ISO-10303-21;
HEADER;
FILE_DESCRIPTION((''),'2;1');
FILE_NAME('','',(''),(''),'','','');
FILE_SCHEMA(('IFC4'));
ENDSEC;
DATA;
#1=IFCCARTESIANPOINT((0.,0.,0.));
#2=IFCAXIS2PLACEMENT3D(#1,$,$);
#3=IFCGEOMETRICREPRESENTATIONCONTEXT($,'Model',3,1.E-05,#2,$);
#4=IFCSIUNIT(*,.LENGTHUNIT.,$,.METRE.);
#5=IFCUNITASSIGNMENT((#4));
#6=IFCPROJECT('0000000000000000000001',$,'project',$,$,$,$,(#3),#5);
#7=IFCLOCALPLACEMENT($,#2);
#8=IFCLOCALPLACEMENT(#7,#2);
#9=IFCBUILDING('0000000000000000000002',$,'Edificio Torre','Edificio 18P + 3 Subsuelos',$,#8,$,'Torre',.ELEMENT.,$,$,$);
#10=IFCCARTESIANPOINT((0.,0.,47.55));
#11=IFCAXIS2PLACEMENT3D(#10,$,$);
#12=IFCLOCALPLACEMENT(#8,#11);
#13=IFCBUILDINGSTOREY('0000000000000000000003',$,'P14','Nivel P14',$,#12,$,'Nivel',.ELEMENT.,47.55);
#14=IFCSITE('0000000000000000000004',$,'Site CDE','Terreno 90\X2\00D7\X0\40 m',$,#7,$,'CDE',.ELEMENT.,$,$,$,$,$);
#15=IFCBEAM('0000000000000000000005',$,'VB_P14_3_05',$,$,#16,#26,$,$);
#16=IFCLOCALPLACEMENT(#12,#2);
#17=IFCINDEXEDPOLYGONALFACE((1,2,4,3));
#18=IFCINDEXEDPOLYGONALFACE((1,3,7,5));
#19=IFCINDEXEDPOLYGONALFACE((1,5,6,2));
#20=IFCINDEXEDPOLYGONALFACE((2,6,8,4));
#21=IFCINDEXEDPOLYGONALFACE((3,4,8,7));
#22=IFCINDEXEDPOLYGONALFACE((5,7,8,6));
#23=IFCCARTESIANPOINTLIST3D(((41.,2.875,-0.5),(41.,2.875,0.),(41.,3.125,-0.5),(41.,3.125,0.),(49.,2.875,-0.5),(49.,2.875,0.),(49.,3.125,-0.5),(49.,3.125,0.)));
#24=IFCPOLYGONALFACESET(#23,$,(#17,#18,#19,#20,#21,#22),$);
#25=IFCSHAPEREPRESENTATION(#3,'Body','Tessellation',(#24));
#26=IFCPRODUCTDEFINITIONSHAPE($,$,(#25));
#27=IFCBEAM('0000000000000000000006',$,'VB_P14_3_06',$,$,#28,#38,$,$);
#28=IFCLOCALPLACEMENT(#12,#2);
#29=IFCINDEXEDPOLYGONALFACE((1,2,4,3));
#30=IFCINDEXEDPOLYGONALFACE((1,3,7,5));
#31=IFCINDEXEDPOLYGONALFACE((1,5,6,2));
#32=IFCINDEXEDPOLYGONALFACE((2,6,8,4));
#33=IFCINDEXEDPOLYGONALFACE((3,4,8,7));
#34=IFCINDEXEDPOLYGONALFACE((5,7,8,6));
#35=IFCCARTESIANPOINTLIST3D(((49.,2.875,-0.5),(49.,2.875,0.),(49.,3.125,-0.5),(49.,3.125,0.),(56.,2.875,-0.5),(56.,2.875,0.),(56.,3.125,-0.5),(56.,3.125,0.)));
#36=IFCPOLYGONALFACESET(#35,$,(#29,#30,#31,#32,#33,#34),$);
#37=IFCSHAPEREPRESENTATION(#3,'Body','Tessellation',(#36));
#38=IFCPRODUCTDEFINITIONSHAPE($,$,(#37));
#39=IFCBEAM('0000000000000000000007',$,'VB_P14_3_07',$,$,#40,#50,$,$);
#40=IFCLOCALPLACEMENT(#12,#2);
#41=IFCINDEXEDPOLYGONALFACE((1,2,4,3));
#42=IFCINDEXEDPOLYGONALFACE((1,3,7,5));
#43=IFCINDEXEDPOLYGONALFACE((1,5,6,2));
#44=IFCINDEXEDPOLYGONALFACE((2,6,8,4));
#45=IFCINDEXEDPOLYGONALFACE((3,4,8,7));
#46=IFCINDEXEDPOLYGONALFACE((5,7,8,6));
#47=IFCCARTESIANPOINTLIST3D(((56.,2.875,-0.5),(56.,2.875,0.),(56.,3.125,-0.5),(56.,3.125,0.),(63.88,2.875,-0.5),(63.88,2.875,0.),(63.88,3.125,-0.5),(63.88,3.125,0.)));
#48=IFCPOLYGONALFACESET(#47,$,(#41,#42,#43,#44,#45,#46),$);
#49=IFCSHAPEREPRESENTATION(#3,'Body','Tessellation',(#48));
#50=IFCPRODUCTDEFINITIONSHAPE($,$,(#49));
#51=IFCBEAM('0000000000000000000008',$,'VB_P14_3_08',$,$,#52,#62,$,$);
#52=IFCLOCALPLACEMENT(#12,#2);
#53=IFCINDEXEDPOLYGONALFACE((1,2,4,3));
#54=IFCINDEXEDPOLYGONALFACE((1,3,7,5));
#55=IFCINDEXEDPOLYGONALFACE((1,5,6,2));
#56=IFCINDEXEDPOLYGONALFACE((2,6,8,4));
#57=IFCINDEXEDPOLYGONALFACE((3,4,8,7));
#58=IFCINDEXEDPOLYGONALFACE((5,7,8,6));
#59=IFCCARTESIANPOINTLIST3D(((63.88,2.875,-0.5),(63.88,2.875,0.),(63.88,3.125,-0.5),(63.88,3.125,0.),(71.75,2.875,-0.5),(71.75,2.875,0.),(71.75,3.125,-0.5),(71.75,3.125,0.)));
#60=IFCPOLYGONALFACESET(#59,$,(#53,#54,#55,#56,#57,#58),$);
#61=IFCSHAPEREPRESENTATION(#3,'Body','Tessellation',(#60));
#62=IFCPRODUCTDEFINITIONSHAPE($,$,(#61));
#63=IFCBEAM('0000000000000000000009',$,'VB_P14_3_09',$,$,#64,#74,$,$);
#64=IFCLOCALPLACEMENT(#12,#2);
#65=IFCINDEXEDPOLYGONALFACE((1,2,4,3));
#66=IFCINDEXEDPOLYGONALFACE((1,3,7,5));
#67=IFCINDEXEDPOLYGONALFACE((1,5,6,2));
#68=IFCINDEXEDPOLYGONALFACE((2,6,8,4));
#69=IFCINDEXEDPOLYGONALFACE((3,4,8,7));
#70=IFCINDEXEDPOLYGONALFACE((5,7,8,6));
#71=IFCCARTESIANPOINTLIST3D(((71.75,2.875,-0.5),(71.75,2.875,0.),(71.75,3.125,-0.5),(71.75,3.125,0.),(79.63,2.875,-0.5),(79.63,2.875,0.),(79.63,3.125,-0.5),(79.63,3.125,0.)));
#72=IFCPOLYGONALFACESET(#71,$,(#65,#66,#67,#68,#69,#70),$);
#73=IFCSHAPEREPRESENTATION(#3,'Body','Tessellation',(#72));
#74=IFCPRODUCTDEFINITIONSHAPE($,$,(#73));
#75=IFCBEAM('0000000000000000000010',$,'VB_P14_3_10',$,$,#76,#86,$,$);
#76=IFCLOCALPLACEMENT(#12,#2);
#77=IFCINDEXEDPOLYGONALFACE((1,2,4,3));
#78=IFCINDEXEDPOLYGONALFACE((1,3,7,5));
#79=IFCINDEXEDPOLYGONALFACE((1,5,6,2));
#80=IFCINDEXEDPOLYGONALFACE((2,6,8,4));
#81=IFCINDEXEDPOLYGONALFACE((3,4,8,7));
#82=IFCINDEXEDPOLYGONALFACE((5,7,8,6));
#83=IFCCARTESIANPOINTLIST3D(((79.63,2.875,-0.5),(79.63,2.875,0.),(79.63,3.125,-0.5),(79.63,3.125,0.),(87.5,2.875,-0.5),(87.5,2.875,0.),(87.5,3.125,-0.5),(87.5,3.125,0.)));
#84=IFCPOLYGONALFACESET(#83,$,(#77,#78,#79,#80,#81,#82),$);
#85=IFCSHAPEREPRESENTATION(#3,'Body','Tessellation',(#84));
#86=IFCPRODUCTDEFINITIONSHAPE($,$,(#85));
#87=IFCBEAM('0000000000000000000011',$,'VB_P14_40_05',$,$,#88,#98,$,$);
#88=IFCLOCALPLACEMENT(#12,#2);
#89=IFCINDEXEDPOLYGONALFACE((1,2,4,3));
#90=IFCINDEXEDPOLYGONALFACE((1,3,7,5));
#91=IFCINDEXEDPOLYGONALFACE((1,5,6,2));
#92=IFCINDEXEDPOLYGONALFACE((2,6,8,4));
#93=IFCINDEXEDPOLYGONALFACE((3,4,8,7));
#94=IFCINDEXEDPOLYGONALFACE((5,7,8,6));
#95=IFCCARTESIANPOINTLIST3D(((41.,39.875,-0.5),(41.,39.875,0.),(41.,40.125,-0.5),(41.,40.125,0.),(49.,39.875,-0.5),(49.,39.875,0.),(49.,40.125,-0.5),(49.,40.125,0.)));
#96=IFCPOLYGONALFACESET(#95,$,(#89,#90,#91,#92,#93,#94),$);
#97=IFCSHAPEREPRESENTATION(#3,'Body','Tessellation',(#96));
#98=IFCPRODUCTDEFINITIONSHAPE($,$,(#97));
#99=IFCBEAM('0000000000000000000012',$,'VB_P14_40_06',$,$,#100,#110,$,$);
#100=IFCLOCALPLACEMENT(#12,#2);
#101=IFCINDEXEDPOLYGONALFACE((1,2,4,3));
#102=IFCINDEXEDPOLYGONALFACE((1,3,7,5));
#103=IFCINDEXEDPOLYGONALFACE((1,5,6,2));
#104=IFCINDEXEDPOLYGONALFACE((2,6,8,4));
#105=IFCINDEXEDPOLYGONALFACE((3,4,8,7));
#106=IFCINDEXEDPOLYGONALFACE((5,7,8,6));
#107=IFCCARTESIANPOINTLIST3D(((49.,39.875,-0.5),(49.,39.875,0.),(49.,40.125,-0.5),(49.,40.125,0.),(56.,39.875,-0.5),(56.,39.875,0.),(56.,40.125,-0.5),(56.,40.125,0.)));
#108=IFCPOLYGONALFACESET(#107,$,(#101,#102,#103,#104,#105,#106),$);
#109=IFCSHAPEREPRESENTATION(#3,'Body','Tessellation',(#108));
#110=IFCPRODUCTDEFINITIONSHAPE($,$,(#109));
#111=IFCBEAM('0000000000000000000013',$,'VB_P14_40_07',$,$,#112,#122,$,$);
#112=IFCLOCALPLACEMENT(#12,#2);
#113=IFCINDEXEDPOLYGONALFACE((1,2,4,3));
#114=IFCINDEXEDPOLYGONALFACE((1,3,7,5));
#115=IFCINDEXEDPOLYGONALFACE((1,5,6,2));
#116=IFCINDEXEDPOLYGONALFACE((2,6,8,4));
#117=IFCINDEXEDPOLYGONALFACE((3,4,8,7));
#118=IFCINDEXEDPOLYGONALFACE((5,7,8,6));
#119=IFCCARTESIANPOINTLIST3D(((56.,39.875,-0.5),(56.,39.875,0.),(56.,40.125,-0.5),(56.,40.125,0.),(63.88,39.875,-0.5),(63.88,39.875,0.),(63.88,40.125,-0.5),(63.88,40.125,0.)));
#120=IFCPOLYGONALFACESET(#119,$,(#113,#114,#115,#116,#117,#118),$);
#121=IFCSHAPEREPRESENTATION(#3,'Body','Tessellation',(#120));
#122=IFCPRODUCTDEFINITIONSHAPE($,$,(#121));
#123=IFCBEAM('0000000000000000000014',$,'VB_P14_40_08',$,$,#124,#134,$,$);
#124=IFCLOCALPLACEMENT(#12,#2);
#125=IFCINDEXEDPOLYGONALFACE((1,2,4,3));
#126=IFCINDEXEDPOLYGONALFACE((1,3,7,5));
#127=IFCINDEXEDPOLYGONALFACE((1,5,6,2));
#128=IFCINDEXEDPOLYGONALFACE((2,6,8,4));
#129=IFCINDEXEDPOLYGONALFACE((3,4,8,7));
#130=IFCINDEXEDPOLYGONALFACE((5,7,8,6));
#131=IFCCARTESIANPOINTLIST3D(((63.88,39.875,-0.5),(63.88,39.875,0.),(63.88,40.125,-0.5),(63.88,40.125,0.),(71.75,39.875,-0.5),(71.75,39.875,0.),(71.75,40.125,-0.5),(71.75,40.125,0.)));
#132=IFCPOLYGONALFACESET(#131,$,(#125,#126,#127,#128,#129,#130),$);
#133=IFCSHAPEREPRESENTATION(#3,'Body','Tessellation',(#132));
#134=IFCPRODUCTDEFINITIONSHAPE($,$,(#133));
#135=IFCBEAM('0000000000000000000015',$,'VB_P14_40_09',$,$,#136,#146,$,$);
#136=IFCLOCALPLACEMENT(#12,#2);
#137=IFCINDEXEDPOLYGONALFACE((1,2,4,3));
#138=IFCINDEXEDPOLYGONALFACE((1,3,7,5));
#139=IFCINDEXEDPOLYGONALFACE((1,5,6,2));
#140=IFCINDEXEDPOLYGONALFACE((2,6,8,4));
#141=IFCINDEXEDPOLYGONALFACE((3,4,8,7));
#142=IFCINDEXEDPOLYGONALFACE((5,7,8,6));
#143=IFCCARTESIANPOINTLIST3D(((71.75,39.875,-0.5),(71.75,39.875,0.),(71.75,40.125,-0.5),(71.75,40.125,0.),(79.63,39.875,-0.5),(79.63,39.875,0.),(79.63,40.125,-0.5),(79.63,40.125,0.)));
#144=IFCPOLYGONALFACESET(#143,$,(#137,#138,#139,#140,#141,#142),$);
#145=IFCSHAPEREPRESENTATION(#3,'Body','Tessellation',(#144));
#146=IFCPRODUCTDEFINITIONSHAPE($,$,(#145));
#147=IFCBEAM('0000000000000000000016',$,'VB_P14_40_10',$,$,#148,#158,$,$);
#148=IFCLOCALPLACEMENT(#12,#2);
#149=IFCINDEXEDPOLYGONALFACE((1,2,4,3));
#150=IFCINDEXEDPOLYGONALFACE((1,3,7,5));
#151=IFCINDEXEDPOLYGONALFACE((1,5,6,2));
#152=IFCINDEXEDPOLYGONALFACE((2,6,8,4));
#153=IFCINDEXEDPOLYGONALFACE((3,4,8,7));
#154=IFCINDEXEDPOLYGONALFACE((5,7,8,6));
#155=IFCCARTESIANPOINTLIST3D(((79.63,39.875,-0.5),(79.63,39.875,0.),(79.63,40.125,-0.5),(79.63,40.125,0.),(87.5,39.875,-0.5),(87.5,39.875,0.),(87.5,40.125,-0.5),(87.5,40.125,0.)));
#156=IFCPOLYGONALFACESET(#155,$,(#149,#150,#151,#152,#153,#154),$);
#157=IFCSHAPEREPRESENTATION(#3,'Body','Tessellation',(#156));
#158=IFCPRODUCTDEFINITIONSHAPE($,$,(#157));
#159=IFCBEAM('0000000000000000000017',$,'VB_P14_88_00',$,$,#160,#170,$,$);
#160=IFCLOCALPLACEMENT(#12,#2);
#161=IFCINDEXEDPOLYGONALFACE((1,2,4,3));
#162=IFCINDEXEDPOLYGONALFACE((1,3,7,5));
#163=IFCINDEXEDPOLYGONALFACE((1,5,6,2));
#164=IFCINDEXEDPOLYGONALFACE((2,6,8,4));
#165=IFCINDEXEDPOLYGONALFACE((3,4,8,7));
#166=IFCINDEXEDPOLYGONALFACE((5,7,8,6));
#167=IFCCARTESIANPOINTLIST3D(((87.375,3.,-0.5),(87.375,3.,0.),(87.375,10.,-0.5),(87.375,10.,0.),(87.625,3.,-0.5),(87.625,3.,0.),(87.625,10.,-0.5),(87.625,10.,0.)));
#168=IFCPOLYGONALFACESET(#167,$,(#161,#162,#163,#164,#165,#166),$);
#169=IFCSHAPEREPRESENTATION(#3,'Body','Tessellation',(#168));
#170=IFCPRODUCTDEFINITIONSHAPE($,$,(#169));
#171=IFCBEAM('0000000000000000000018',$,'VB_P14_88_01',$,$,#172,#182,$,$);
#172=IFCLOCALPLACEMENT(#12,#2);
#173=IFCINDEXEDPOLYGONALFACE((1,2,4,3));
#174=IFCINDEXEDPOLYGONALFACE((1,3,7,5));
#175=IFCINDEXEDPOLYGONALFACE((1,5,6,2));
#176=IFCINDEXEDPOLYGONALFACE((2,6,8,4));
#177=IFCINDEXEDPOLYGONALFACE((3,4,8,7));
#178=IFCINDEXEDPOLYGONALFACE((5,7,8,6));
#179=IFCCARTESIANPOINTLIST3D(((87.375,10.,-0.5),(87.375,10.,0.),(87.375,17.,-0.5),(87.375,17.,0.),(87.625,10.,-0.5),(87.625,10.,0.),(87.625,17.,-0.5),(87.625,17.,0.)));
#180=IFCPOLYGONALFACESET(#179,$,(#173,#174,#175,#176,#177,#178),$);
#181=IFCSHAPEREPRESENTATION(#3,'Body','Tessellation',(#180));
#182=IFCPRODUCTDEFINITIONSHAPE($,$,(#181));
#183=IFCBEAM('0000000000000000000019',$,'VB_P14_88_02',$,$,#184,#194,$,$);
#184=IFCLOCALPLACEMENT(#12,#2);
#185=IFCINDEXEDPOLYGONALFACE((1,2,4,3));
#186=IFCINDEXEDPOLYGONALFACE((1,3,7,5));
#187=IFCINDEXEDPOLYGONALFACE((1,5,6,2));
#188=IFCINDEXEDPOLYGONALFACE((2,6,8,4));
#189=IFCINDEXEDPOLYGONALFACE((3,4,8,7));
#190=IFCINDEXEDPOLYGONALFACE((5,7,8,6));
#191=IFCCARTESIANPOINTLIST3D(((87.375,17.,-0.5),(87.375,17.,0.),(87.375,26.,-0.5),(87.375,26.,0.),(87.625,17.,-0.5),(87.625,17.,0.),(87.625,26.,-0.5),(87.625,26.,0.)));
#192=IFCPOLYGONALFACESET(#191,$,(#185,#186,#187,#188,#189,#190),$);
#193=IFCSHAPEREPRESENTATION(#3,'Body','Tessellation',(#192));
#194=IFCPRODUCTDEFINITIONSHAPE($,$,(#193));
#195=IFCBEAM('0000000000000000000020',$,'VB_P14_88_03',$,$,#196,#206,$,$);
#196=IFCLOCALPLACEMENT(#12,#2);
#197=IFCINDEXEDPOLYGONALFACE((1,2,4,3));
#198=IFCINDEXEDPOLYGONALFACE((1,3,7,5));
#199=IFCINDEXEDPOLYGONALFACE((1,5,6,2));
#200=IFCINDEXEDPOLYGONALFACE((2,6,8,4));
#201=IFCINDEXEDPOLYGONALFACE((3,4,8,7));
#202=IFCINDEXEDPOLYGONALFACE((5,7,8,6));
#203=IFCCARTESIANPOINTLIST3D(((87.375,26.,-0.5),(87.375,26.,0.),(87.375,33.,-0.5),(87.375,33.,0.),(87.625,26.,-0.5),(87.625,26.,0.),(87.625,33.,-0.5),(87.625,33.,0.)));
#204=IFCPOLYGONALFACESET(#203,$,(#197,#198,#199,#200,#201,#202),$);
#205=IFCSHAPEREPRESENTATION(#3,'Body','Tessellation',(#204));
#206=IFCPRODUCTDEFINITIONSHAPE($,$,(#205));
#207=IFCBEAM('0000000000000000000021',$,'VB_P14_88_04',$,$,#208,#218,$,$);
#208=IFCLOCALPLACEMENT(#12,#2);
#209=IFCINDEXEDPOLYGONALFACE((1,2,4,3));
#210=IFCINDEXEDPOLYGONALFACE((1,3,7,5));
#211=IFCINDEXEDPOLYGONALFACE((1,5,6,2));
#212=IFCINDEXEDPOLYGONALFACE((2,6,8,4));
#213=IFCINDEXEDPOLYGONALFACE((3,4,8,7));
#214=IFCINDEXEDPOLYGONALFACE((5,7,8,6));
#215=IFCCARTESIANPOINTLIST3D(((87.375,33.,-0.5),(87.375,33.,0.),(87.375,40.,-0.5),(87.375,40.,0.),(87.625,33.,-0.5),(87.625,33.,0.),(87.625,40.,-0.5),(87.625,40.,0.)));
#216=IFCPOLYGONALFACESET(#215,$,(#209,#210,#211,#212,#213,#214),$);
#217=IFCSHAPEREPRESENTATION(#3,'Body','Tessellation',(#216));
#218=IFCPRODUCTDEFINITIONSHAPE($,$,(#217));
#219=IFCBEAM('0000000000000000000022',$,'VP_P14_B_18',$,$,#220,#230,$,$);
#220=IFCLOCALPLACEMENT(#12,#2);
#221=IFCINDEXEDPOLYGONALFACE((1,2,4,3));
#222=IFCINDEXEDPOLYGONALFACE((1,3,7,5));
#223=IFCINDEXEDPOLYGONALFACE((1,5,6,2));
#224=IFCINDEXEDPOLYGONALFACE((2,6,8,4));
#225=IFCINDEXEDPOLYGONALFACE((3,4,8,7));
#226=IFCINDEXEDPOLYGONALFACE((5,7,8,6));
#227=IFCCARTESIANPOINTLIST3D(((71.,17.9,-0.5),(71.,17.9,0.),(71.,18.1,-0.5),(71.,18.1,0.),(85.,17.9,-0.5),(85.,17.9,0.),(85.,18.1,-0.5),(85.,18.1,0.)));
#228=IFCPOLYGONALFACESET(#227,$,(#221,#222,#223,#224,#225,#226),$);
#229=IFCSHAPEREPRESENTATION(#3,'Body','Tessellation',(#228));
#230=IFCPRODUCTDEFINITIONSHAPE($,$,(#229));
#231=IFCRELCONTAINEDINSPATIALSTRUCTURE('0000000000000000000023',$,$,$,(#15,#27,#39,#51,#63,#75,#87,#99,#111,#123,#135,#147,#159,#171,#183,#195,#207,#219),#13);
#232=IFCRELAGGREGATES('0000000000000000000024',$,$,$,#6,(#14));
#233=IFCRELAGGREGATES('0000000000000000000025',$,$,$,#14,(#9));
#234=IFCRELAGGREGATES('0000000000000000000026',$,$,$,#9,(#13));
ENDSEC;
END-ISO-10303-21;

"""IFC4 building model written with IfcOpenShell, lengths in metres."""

from ifc_helpers import new_model, si_unit, frame, origin, origin_2d, place, context, project, spatial, rectangle, extrude, element, save


model = new_model("IFC4")

# Units and contexts
model_context = context("Model", 3, precision=1e-05, world=origin())
ifc_project = project(units=[si_unit("LENGTHUNIT", "METRE")], contexts=[model_context])

# Site, building, storey
site_placement = place(None, origin())
site = spatial("IfcSite", under=ifc_project, at=site_placement, Name="Site CDE", Description="Terreno 90×40 m", LongName="CDE", CompositionType="ELEMENT")
building_placement = place(site_placement, origin())
building = spatial("IfcBuilding", under=site, at=building_placement, Name="Edificio Torre", Description="Edificio 18P + 3 Subsuelos", LongName="Torre", CompositionType="ELEMENT")
storey_placement = place(building_placement, frame((0.0, 0.0, 47.55)))
storey = spatial("IfcBuildingStorey", under=building, at=storey_placement, Name="P14", Description="Nivel P14", LongName="Nivel", CompositionType="ELEMENT", Elevation=47.55)

# Beams
beam_1_placement = place(storey_placement, frame((45.0, 3.0, -0.5)))
element("IfcBeam", 1, at=beam_1_placement, inside=storey, Name="VB_P14_3_05", context=model_context, shape_type="SweptSolid", body=[
    extrude(rectangle(XDim=8.0, YDim=0.25, at=origin_2d()), origin(), (0.0, 0.0, 1.0), 0.5),
])
beam_2_placement = place(storey_placement, frame((52.5, 3.0, -0.5)))
element("IfcBeam", 2, at=beam_2_placement, inside=storey, Name="VB_P14_3_06", context=model_context, shape_type="SweptSolid", body=[
    extrude(rectangle(XDim=7.0, YDim=0.25, at=origin_2d()), origin(), (0.0, 0.0, 1.0), 0.5),
])
beam_3_placement = place(storey_placement, frame((59.94, 3.0, -0.5)))
element("IfcBeam", 3, at=beam_3_placement, inside=storey, Name="VB_P14_3_07", context=model_context, shape_type="SweptSolid", body=[
    extrude(rectangle(XDim=7.88, YDim=0.25, at=origin_2d()), origin(), (0.0, 0.0, 1.0), 0.5),
])
beam_4_placement = place(storey_placement, frame((67.815, 3.0, -0.5)))
element("IfcBeam", 4, at=beam_4_placement, inside=storey, Name="VB_P14_3_08", context=model_context, shape_type="SweptSolid", body=[
    extrude(rectangle(XDim=7.87, YDim=0.25, at=origin_2d()), origin(), (0.0, 0.0, 1.0), 0.5),
])
beam_5_placement = place(storey_placement, frame((75.69, 3.0, -0.5)))
element("IfcBeam", 5, at=beam_5_placement, inside=storey, Name="VB_P14_3_09", context=model_context, shape_type="SweptSolid", body=[
    extrude(rectangle(XDim=7.88, YDim=0.25, at=origin_2d()), origin(), (0.0, 0.0, 1.0), 0.5),
])
beam_6_placement = place(storey_placement, frame((83.565, 3.0, -0.5)))
element("IfcBeam", 6, at=beam_6_placement, inside=storey, Name="VB_P14_3_10", context=model_context, shape_type="SweptSolid", body=[
    extrude(rectangle(XDim=7.87, YDim=0.25, at=origin_2d()), origin(), (0.0, 0.0, 1.0), 0.5),
])
beam_7_placement = place(storey_placement, frame((45.0, 40.0, -0.5)))
element("IfcBeam", 7, at=beam_7_placement, inside=storey, Name="VB_P14_40_05", context=model_context, shape_type="SweptSolid", body=[
    extrude(rectangle(XDim=8.0, YDim=0.25, at=origin_2d()), origin(), (0.0, 0.0, 1.0), 0.5),
])
beam_8_placement = place(storey_placement, frame((52.5, 40.0, -0.5)))
element("IfcBeam", 8, at=beam_8_placement, inside=storey, Name="VB_P14_40_06", context=model_context, shape_type="SweptSolid", body=[
    extrude(rectangle(XDim=7.0, YDim=0.25, at=origin_2d()), origin(), (0.0, 0.0, 1.0), 0.5),
])
beam_9_placement = place(storey_placement, frame((59.94, 40.0, -0.5)))
element("IfcBeam", 9, at=beam_9_placement, inside=storey, Name="VB_P14_40_07", context=model_context, shape_type="SweptSolid", body=[
    extrude(rectangle(XDim=7.88, YDim=0.25, at=origin_2d()), origin(), (0.0, 0.0, 1.0), 0.5),
])
beam_10_placement = place(storey_placement, frame((67.815, 40.0, -0.5)))
element("IfcBeam", 10, at=beam_10_placement, inside=storey, Name="VB_P14_40_08", context=model_context, shape_type="SweptSolid", body=[
    extrude(rectangle(XDim=7.87, YDim=0.25, at=origin_2d()), origin(), (0.0, 0.0, 1.0), 0.5),
])
beam_11_placement = place(storey_placement, frame((75.69, 40.0, -0.5)))
element("IfcBeam", 11, at=beam_11_placement, inside=storey, Name="VB_P14_40_09", context=model_context, shape_type="SweptSolid", body=[
    extrude(rectangle(XDim=7.88, YDim=0.25, at=origin_2d()), origin(), (0.0, 0.0, 1.0), 0.5),
])
beam_12_placement = place(storey_placement, frame((83.565, 40.0, -0.5)))
element("IfcBeam", 12, at=beam_12_placement, inside=storey, Name="VB_P14_40_10", context=model_context, shape_type="SweptSolid", body=[
    extrude(rectangle(XDim=7.87, YDim=0.25, at=origin_2d()), origin(), (0.0, 0.0, 1.0), 0.5),
])
for number, where, name in (
    (13, (87.5, 6.5, -0.5), "VB_P14_88_00"),
    (14, (87.5, 13.5, -0.5), "VB_P14_88_01"),
):
    element("IfcBeam", number, at=place(storey_placement, frame(where)), inside=storey, Name=name, context=model_context, shape_type="SweptSolid", body=[
        extrude(rectangle(XDim=0.25, YDim=7.0, at=origin_2d()), origin(), (0.0, 0.0, 1.0), 0.5),
    ])
beam_13_placement = place(storey_placement, frame((87.5, 21.5, -0.5)))
element("IfcBeam", 15, at=beam_13_placement, inside=storey, Name="VB_P14_88_02", context=model_context, shape_type="SweptSolid", body=[
    extrude(rectangle(XDim=0.25, YDim=9.0, at=origin_2d()), origin(), (0.0, 0.0, 1.0), 0.5),
])
for number, where, name in (
    (16, (87.5, 29.5, -0.5), "VB_P14_88_03"),
    (17, (87.5, 36.5, -0.5), "VB_P14_88_04"),
):
    element("IfcBeam", number, at=place(storey_placement, frame(where)), inside=storey, Name=name, context=model_context, shape_type="SweptSolid", body=[
        extrude(rectangle(XDim=0.25, YDim=7.0, at=origin_2d()), origin(), (0.0, 0.0, 1.0), 0.5),
    ])
for number, where, name in (
    (18, (78.0, 18.0, -0.5), "VP_P14_B_18"),
):
    element("IfcBeam", number, at=place(storey_placement, frame(where)), inside=storey, Name=name, context=model_context, shape_type="SweptSolid", body=[
        extrude(rectangle(XDim=14.0, YDim=0.2, at=origin_2d()), origin(), (0.0, 0.0, 1.0), 0.5),
    ])

save(model, "model.ifc")
